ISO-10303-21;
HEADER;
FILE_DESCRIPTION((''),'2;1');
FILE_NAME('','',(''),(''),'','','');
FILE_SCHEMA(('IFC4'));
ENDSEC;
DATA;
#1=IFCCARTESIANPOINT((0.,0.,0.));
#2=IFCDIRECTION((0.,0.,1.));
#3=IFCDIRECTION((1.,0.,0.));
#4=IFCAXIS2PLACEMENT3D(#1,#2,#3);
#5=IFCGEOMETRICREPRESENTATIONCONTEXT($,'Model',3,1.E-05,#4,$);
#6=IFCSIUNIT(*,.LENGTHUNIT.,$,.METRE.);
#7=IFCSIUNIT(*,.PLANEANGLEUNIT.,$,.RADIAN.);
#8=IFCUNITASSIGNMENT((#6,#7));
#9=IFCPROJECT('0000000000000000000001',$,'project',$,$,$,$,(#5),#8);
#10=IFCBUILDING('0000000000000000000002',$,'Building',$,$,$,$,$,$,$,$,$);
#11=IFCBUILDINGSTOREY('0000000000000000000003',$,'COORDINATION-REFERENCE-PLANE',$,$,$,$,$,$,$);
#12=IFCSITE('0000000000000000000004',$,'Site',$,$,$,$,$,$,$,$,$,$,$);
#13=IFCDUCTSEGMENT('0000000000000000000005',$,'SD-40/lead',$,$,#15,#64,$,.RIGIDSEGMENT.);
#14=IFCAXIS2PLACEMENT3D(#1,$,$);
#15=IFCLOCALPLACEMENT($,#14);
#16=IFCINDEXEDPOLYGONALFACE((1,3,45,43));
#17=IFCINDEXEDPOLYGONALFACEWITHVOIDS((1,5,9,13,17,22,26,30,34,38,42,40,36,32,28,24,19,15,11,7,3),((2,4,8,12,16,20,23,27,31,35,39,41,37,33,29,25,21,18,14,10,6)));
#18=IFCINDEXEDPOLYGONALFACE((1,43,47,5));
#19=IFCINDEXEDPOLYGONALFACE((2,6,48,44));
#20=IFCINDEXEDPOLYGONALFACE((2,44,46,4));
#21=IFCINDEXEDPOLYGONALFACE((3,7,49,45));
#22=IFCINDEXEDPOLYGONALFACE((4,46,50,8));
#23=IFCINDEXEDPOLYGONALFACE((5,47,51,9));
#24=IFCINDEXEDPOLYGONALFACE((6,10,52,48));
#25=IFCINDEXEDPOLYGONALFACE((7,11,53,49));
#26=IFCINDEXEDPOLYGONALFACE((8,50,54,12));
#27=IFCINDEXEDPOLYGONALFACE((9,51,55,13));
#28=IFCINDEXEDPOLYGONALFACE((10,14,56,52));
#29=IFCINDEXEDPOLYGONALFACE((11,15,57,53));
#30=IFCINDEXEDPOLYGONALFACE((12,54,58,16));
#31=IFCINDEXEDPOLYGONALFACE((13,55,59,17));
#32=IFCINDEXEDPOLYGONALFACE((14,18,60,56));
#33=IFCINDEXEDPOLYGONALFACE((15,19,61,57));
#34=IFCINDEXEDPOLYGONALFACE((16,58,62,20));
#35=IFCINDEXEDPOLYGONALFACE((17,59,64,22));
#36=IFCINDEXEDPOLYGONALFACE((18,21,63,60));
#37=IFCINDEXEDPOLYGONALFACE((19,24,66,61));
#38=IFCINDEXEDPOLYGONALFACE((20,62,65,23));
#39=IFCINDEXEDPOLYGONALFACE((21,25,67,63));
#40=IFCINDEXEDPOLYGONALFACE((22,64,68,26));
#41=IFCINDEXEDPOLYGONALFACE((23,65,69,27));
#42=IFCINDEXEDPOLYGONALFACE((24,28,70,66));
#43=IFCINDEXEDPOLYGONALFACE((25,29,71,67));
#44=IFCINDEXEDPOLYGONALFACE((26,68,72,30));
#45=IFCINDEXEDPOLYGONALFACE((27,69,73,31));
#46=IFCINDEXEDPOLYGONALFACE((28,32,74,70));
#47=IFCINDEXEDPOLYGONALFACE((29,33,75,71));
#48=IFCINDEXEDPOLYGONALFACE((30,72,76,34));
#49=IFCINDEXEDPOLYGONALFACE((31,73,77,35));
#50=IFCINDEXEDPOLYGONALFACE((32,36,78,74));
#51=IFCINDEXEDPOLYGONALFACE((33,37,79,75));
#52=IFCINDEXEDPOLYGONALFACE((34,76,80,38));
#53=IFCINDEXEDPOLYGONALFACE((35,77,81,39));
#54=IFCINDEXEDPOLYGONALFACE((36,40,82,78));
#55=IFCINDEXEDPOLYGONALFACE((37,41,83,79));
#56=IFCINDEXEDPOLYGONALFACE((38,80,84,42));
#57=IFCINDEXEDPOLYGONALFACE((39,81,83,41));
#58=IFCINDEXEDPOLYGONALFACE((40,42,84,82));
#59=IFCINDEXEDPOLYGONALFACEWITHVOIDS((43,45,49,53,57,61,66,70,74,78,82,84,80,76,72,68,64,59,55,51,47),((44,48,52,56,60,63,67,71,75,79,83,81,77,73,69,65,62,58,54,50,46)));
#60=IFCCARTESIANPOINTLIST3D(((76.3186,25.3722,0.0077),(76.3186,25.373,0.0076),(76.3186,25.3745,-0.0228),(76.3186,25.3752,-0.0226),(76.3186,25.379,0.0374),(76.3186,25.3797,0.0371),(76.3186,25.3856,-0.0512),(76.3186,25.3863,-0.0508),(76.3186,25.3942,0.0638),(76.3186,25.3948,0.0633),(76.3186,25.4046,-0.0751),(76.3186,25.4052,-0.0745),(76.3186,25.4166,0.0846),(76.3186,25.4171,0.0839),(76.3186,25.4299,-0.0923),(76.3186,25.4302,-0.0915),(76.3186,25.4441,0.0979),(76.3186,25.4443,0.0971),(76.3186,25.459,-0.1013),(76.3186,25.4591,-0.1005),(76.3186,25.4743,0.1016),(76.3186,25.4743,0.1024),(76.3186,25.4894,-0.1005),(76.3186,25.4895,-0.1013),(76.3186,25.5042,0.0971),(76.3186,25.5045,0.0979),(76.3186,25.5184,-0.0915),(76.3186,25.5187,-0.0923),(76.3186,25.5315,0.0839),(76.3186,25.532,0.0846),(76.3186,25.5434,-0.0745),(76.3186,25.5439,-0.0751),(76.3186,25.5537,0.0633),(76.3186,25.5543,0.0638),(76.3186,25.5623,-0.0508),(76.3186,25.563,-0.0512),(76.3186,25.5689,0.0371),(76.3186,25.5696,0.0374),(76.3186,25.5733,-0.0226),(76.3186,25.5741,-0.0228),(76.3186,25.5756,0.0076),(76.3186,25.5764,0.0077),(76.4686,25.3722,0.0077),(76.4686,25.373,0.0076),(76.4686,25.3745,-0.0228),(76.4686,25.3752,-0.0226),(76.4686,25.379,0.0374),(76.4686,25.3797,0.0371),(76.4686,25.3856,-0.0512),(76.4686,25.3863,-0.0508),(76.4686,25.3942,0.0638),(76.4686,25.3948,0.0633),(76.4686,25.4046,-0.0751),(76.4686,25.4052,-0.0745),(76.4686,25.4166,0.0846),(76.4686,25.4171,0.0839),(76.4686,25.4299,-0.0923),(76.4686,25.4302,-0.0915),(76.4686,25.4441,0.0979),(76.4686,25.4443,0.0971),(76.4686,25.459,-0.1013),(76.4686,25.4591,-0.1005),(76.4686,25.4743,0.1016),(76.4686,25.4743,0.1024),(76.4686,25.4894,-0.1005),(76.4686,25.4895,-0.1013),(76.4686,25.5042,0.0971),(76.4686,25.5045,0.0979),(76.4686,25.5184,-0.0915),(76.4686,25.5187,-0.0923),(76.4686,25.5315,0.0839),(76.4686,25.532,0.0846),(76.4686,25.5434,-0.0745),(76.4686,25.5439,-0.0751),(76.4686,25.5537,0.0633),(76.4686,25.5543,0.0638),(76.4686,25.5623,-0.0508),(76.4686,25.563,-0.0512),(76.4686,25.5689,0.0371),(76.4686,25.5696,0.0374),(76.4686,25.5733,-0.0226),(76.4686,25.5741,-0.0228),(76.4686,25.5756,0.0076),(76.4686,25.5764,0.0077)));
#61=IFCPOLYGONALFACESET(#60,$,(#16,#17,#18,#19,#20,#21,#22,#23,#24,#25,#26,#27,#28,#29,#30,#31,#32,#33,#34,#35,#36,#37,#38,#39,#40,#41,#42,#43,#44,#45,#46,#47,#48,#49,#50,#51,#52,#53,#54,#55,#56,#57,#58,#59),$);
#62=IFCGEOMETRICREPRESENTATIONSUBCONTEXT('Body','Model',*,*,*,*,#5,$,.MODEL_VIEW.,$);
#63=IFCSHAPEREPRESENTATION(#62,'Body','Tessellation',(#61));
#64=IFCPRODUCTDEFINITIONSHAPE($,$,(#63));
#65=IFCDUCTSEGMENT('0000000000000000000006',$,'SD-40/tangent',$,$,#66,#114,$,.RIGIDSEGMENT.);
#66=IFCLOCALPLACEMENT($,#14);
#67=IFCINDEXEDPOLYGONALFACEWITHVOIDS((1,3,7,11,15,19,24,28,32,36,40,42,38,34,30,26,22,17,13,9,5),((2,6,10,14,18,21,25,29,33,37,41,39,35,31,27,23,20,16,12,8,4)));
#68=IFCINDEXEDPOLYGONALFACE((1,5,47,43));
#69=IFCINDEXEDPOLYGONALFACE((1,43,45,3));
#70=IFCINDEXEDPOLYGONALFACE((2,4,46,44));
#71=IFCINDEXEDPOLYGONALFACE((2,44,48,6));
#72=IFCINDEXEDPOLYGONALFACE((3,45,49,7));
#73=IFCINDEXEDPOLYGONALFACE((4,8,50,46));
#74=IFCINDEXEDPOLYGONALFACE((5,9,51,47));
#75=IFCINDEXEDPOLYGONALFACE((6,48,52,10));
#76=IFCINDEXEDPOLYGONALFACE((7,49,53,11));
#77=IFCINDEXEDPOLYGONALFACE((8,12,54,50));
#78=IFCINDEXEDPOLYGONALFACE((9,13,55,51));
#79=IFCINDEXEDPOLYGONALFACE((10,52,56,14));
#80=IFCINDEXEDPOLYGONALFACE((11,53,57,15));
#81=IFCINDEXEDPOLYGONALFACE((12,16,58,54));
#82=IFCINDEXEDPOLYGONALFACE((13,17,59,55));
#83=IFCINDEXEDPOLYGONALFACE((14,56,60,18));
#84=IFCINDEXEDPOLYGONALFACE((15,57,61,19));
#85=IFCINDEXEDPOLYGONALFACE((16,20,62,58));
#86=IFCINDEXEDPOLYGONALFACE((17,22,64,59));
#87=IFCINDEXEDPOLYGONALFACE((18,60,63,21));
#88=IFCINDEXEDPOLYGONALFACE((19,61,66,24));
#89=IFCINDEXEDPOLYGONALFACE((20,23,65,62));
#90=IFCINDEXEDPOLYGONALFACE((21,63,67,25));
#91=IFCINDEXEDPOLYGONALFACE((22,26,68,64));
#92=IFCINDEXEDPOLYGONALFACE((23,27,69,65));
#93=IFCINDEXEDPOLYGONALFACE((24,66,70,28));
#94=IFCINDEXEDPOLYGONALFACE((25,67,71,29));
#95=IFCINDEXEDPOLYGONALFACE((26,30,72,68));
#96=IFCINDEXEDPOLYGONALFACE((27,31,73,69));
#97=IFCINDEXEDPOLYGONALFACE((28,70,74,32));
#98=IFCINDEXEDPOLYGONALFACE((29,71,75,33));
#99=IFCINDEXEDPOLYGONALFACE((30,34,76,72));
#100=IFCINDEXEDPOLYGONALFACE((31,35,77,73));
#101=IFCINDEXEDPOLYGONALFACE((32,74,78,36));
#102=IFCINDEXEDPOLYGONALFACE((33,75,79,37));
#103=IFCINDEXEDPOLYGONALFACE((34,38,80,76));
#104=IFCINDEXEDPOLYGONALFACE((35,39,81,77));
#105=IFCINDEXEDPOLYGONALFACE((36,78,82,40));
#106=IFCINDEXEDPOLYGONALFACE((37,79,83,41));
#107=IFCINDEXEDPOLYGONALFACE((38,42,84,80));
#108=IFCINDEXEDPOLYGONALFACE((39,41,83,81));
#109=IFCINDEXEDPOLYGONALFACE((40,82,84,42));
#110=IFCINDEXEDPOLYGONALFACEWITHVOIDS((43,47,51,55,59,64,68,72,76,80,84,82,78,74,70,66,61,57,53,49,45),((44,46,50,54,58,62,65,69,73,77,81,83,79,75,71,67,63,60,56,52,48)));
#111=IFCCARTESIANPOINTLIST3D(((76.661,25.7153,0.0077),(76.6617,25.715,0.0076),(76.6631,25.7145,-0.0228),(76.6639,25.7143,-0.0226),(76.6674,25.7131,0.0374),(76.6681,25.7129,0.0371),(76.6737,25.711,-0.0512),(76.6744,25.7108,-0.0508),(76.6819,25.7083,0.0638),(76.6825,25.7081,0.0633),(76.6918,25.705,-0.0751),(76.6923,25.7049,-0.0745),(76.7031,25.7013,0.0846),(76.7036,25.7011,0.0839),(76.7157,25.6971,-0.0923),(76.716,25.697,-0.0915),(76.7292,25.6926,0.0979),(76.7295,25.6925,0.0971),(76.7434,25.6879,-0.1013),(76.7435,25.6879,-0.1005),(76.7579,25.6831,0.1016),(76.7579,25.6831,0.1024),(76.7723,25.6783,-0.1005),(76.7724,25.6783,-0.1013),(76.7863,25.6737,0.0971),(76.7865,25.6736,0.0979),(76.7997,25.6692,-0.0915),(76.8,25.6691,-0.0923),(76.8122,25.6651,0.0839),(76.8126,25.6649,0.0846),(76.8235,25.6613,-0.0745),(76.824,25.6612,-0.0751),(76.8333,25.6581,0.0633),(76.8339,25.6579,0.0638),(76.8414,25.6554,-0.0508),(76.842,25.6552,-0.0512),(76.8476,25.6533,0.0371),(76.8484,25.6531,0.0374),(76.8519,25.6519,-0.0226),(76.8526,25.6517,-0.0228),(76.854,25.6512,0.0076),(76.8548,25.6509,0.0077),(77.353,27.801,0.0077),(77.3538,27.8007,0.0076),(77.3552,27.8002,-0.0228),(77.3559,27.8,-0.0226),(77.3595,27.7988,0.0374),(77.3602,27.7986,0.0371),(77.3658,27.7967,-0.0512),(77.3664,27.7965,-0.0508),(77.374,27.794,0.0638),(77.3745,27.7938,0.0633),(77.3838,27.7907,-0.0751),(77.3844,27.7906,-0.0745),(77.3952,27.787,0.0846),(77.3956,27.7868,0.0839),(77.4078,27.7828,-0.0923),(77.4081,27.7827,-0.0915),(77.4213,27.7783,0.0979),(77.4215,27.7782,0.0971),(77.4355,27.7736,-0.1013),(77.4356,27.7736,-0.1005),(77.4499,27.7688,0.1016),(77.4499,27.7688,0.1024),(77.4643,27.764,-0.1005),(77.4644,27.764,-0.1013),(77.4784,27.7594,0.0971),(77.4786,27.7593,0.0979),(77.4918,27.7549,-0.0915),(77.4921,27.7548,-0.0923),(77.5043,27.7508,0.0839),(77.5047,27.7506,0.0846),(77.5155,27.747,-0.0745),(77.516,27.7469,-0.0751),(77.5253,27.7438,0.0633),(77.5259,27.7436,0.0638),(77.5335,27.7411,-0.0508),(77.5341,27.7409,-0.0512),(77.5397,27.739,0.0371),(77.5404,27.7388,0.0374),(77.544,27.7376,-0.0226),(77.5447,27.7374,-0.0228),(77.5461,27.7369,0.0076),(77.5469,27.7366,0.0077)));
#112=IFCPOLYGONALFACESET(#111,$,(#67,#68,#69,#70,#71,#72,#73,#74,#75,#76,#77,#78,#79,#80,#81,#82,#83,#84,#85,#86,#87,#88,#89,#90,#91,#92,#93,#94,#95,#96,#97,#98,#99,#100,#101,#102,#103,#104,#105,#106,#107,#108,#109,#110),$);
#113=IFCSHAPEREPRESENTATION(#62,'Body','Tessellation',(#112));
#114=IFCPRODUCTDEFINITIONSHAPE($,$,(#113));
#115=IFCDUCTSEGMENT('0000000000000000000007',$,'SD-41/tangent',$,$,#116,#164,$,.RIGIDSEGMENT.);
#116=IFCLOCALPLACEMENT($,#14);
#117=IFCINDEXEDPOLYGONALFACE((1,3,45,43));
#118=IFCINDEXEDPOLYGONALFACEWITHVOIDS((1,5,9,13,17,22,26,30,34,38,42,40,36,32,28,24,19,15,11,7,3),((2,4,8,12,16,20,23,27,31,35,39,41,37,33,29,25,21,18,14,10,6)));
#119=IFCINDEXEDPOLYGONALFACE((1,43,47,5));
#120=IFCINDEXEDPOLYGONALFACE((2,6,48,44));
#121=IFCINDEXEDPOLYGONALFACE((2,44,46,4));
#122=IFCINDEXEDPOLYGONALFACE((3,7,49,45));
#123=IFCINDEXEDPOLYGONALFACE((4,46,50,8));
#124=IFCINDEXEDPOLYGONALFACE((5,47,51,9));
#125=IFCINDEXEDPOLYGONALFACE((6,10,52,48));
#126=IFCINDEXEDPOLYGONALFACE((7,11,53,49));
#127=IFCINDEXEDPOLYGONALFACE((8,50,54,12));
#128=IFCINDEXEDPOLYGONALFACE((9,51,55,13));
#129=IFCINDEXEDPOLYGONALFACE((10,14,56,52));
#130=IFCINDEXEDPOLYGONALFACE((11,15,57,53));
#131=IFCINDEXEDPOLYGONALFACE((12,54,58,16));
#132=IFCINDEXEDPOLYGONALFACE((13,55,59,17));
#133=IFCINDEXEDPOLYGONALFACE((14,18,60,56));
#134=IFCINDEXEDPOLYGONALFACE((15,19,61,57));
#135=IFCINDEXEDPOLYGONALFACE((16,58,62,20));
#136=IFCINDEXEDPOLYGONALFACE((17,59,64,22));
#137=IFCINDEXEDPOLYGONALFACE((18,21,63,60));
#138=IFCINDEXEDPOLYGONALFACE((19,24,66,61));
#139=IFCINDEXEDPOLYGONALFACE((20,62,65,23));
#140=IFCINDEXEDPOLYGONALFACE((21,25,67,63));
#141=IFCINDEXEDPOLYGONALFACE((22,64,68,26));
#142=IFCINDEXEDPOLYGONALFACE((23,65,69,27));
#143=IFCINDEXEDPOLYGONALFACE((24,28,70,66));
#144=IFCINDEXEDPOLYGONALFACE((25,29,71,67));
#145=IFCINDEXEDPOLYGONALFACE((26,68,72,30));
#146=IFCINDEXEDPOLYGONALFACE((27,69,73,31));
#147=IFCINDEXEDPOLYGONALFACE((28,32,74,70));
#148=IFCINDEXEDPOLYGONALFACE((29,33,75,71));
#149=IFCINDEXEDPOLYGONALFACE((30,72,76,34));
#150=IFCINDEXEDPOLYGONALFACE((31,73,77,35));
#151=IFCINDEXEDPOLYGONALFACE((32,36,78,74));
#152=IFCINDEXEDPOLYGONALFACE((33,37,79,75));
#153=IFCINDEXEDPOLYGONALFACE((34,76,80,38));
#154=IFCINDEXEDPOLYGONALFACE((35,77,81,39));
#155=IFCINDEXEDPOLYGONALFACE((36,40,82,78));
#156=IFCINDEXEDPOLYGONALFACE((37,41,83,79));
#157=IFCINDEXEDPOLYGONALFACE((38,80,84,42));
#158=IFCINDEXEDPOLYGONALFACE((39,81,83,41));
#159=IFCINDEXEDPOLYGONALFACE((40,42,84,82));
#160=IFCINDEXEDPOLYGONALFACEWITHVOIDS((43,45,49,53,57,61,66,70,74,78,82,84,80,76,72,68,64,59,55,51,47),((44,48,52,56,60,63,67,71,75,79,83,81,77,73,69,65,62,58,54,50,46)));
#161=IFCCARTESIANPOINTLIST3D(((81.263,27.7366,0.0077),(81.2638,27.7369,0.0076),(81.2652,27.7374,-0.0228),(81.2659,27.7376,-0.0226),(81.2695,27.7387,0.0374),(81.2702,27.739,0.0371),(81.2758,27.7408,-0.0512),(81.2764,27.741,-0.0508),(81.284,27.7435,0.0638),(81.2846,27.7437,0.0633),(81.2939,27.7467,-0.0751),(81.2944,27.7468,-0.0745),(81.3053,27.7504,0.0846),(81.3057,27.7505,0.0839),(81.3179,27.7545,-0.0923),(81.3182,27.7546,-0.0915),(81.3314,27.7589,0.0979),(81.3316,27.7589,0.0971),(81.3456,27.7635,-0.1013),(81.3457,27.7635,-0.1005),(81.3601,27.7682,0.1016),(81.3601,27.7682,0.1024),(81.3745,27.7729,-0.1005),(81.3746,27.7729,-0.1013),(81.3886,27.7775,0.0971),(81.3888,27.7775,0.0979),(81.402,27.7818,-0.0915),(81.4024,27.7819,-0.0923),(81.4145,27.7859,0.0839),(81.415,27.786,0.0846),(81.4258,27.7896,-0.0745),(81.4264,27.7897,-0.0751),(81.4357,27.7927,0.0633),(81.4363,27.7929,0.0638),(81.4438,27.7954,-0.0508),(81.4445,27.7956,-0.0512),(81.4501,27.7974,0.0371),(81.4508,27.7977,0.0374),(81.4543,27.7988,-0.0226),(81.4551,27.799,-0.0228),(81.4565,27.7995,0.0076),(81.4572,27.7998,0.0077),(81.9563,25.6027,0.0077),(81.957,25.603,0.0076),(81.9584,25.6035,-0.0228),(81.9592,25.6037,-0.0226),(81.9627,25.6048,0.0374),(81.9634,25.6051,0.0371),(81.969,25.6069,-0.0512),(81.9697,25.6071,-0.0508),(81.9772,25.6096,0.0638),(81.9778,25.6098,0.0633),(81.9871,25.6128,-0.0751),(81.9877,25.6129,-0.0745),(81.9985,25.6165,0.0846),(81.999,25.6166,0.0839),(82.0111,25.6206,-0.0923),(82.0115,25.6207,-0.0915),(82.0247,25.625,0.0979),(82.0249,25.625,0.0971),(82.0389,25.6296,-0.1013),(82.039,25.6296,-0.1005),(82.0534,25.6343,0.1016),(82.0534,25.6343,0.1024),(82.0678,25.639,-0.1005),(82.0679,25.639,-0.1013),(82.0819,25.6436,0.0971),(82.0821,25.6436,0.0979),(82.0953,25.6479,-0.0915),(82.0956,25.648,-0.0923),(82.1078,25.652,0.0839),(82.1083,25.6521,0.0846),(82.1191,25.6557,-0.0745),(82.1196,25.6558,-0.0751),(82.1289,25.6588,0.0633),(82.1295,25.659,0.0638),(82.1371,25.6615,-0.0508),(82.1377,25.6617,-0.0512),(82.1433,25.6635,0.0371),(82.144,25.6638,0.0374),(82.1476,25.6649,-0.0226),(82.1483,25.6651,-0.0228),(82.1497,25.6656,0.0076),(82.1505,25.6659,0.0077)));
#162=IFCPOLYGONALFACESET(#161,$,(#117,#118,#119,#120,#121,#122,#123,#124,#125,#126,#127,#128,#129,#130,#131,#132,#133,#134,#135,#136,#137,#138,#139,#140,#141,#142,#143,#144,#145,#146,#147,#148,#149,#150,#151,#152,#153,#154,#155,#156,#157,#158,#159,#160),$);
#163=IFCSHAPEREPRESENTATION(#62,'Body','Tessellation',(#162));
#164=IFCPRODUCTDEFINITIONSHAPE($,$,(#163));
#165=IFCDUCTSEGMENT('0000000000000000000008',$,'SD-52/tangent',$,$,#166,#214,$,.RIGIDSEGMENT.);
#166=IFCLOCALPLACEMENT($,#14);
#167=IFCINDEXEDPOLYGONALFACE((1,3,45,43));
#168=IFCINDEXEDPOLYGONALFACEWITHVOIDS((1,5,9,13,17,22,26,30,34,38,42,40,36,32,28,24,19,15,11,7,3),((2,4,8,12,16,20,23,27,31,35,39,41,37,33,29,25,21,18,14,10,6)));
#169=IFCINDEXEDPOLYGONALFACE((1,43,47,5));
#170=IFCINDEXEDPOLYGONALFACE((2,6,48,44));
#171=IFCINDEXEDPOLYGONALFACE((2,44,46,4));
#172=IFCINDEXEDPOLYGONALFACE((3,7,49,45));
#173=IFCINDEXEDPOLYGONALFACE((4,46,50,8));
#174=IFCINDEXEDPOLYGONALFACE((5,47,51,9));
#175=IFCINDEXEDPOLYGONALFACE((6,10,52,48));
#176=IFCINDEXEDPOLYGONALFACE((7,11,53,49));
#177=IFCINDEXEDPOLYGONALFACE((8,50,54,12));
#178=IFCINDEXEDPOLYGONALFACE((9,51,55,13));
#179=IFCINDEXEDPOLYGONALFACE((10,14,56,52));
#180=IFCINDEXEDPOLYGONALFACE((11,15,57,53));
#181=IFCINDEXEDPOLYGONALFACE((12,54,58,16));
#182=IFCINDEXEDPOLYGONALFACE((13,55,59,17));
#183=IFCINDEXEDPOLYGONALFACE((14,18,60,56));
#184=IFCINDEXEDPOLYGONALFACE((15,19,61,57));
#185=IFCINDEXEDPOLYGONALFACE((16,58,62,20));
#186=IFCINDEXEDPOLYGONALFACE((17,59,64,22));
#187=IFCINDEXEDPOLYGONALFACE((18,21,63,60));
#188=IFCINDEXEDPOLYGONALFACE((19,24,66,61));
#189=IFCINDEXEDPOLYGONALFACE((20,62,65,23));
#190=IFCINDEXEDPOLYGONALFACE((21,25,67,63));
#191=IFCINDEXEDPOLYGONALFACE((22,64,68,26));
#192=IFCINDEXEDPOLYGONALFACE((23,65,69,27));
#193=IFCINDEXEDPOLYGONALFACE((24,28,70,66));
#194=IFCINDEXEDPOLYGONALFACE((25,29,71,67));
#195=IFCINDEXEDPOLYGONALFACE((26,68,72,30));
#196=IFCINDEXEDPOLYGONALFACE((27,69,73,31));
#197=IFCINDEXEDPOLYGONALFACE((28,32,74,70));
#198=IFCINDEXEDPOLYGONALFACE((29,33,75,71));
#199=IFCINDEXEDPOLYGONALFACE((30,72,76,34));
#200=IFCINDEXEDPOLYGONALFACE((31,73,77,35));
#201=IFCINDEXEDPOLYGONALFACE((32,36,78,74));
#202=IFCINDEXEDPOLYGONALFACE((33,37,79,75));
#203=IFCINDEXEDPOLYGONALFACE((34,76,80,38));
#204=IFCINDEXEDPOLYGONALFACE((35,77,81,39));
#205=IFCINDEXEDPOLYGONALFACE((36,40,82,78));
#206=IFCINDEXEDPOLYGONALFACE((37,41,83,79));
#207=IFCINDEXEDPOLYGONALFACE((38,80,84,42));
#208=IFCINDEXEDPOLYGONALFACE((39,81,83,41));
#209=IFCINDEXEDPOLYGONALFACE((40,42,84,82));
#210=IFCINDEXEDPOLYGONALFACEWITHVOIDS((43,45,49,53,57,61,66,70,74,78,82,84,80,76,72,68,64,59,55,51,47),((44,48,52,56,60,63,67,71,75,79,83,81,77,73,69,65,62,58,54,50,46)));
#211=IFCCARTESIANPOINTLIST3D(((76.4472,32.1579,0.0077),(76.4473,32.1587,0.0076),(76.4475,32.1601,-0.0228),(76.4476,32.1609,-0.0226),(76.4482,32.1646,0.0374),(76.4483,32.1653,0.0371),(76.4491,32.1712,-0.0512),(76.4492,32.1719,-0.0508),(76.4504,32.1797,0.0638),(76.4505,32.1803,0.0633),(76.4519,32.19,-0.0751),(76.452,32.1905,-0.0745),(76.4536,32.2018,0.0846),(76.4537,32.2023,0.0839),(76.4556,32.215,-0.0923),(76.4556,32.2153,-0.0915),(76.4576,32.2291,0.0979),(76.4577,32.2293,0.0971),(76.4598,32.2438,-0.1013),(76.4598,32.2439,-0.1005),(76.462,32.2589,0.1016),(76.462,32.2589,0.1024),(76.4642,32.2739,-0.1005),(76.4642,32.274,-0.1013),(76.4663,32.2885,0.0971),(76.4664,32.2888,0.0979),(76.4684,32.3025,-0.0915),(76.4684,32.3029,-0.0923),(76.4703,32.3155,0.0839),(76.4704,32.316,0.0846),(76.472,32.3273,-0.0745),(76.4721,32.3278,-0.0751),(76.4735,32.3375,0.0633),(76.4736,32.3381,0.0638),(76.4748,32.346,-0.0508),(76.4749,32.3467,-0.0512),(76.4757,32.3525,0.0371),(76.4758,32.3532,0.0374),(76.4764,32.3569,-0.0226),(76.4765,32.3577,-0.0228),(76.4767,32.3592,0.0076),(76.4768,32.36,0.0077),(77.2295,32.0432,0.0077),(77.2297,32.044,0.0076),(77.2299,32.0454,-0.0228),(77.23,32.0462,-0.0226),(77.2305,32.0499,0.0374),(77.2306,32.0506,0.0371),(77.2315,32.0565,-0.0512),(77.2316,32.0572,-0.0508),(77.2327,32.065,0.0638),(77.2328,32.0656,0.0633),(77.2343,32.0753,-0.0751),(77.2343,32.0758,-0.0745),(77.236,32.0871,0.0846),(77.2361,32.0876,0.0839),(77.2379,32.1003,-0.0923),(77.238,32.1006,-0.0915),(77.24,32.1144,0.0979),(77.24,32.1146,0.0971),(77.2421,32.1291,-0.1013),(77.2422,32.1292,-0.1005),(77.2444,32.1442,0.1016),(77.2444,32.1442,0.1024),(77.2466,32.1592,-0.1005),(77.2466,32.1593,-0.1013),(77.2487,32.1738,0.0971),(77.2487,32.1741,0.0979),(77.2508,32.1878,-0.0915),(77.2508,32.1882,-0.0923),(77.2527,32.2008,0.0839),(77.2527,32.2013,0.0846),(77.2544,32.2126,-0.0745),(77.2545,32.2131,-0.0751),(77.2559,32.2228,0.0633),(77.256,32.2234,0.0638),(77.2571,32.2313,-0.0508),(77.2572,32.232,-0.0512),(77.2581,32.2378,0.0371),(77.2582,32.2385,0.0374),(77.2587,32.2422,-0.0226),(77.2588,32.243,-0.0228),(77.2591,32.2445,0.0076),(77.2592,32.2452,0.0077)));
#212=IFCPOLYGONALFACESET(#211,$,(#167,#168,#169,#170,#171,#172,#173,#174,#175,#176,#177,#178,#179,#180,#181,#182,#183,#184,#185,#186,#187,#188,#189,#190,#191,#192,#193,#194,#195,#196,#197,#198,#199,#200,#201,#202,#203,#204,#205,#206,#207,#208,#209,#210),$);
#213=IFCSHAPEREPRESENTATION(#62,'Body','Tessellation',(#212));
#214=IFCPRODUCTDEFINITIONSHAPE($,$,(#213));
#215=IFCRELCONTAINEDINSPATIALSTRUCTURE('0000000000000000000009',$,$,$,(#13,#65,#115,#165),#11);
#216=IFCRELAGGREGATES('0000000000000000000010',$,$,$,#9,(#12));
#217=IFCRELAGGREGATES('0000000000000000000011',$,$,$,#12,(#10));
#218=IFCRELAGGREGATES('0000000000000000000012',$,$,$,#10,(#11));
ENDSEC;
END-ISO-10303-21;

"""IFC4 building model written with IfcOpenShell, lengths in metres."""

from ifc_helpers import new_model, si_unit, frame, origin_with_axes, place, context, subcontext, project, spatial, hollow_circle, extrude, element, save


model = new_model("IFC4")

# Units and contexts
model_context_1 = context("Model", 3, precision=1e-05, world=origin_with_axes())
body_context_1 = subcontext(model_context_1, "Body", "Model", "MODEL_VIEW")
ifc_project = project(units=[si_unit("LENGTHUNIT", "METRE"), si_unit("PLANEANGLEUNIT", "RADIAN")], contexts=[model_context_1])

# Site, building, storey
site = spatial("IfcSite", under=ifc_project, Name="Site")
building = spatial("IfcBuilding", under=site, Name="Building")
storey = spatial("IfcBuildingStorey", under=building, Name="COORDINATION-REFERENCE-PLANE")

# Duct segment
duct_segment_1_placement = place(None, frame((76.3186, 25.4743, 0.0), z_axis=(1.0, 0.0, 0.0), x_axis=(0.0, 0.0, 1.0)))
element("IfcDuctSegment", 1, at=duct_segment_1_placement, inside=storey, Name="SD-40/lead", PredefinedType="RIGIDSEGMENT", context=body_context_1, shape_type="SweptSolid", body=[
    extrude(hollow_circle(Radius=0.1024, WallThickness=0.0008), origin_with_axes(), (0.0, 0.0, 1.0), 0.15),
])

# Duct segment
duct_segment_2_placement = place(None, frame((76.7579, 25.6831, 0.0), z_axis=(0.314929, 0.949115, 0.0), x_axis=(0.0, 0.0, 1.0)))
element("IfcDuctSegment", 2, at=duct_segment_2_placement, inside=storey, Name="SD-40/tangent", PredefinedType="RIGIDSEGMENT", context=body_context_1, shape_type="SweptSolid", body=[
    extrude(hollow_circle(Radius=0.1024, WallThickness=0.0008), origin_with_axes(), (0.0, 0.0, 1.0), 2.1975),
])

# Duct segment
duct_segment_3_placement = place(None, frame((82.0534, 25.6343, 0.0), z_axis=(-0.30899, 0.951065, 0.0), x_axis=(0.0, 0.0, 1.0)))
element("IfcDuctSegment", 3, at=duct_segment_3_placement, inside=storey, Name="SD-41/tangent", PredefinedType="RIGIDSEGMENT", context=body_context_1, shape_type="SweptSolid", body=[
    extrude(hollow_circle(Radius=0.1024, WallThickness=0.0008), origin_with_axes(), (0.0, 0.0, 1.0), 2.2437),
])

# Duct segment
duct_segment_4_placement = place(None, frame((76.462, 32.2589, 0.0), z_axis=(0.989423, -0.145062, 0.0), x_axis=(0.0, 0.0, 1.0)))
element("IfcDuctSegment", 4, at=duct_segment_4_placement, inside=storey, Name="SD-52/tangent", PredefinedType="RIGIDSEGMENT", context=body_context_1, shape_type="SweptSolid", body=[
    extrude(hollow_circle(Radius=0.1024, WallThickness=0.0008), origin_with_axes(), (0.0, 0.0, 1.0), 0.7907),
])

save(model, "model.ifc")
